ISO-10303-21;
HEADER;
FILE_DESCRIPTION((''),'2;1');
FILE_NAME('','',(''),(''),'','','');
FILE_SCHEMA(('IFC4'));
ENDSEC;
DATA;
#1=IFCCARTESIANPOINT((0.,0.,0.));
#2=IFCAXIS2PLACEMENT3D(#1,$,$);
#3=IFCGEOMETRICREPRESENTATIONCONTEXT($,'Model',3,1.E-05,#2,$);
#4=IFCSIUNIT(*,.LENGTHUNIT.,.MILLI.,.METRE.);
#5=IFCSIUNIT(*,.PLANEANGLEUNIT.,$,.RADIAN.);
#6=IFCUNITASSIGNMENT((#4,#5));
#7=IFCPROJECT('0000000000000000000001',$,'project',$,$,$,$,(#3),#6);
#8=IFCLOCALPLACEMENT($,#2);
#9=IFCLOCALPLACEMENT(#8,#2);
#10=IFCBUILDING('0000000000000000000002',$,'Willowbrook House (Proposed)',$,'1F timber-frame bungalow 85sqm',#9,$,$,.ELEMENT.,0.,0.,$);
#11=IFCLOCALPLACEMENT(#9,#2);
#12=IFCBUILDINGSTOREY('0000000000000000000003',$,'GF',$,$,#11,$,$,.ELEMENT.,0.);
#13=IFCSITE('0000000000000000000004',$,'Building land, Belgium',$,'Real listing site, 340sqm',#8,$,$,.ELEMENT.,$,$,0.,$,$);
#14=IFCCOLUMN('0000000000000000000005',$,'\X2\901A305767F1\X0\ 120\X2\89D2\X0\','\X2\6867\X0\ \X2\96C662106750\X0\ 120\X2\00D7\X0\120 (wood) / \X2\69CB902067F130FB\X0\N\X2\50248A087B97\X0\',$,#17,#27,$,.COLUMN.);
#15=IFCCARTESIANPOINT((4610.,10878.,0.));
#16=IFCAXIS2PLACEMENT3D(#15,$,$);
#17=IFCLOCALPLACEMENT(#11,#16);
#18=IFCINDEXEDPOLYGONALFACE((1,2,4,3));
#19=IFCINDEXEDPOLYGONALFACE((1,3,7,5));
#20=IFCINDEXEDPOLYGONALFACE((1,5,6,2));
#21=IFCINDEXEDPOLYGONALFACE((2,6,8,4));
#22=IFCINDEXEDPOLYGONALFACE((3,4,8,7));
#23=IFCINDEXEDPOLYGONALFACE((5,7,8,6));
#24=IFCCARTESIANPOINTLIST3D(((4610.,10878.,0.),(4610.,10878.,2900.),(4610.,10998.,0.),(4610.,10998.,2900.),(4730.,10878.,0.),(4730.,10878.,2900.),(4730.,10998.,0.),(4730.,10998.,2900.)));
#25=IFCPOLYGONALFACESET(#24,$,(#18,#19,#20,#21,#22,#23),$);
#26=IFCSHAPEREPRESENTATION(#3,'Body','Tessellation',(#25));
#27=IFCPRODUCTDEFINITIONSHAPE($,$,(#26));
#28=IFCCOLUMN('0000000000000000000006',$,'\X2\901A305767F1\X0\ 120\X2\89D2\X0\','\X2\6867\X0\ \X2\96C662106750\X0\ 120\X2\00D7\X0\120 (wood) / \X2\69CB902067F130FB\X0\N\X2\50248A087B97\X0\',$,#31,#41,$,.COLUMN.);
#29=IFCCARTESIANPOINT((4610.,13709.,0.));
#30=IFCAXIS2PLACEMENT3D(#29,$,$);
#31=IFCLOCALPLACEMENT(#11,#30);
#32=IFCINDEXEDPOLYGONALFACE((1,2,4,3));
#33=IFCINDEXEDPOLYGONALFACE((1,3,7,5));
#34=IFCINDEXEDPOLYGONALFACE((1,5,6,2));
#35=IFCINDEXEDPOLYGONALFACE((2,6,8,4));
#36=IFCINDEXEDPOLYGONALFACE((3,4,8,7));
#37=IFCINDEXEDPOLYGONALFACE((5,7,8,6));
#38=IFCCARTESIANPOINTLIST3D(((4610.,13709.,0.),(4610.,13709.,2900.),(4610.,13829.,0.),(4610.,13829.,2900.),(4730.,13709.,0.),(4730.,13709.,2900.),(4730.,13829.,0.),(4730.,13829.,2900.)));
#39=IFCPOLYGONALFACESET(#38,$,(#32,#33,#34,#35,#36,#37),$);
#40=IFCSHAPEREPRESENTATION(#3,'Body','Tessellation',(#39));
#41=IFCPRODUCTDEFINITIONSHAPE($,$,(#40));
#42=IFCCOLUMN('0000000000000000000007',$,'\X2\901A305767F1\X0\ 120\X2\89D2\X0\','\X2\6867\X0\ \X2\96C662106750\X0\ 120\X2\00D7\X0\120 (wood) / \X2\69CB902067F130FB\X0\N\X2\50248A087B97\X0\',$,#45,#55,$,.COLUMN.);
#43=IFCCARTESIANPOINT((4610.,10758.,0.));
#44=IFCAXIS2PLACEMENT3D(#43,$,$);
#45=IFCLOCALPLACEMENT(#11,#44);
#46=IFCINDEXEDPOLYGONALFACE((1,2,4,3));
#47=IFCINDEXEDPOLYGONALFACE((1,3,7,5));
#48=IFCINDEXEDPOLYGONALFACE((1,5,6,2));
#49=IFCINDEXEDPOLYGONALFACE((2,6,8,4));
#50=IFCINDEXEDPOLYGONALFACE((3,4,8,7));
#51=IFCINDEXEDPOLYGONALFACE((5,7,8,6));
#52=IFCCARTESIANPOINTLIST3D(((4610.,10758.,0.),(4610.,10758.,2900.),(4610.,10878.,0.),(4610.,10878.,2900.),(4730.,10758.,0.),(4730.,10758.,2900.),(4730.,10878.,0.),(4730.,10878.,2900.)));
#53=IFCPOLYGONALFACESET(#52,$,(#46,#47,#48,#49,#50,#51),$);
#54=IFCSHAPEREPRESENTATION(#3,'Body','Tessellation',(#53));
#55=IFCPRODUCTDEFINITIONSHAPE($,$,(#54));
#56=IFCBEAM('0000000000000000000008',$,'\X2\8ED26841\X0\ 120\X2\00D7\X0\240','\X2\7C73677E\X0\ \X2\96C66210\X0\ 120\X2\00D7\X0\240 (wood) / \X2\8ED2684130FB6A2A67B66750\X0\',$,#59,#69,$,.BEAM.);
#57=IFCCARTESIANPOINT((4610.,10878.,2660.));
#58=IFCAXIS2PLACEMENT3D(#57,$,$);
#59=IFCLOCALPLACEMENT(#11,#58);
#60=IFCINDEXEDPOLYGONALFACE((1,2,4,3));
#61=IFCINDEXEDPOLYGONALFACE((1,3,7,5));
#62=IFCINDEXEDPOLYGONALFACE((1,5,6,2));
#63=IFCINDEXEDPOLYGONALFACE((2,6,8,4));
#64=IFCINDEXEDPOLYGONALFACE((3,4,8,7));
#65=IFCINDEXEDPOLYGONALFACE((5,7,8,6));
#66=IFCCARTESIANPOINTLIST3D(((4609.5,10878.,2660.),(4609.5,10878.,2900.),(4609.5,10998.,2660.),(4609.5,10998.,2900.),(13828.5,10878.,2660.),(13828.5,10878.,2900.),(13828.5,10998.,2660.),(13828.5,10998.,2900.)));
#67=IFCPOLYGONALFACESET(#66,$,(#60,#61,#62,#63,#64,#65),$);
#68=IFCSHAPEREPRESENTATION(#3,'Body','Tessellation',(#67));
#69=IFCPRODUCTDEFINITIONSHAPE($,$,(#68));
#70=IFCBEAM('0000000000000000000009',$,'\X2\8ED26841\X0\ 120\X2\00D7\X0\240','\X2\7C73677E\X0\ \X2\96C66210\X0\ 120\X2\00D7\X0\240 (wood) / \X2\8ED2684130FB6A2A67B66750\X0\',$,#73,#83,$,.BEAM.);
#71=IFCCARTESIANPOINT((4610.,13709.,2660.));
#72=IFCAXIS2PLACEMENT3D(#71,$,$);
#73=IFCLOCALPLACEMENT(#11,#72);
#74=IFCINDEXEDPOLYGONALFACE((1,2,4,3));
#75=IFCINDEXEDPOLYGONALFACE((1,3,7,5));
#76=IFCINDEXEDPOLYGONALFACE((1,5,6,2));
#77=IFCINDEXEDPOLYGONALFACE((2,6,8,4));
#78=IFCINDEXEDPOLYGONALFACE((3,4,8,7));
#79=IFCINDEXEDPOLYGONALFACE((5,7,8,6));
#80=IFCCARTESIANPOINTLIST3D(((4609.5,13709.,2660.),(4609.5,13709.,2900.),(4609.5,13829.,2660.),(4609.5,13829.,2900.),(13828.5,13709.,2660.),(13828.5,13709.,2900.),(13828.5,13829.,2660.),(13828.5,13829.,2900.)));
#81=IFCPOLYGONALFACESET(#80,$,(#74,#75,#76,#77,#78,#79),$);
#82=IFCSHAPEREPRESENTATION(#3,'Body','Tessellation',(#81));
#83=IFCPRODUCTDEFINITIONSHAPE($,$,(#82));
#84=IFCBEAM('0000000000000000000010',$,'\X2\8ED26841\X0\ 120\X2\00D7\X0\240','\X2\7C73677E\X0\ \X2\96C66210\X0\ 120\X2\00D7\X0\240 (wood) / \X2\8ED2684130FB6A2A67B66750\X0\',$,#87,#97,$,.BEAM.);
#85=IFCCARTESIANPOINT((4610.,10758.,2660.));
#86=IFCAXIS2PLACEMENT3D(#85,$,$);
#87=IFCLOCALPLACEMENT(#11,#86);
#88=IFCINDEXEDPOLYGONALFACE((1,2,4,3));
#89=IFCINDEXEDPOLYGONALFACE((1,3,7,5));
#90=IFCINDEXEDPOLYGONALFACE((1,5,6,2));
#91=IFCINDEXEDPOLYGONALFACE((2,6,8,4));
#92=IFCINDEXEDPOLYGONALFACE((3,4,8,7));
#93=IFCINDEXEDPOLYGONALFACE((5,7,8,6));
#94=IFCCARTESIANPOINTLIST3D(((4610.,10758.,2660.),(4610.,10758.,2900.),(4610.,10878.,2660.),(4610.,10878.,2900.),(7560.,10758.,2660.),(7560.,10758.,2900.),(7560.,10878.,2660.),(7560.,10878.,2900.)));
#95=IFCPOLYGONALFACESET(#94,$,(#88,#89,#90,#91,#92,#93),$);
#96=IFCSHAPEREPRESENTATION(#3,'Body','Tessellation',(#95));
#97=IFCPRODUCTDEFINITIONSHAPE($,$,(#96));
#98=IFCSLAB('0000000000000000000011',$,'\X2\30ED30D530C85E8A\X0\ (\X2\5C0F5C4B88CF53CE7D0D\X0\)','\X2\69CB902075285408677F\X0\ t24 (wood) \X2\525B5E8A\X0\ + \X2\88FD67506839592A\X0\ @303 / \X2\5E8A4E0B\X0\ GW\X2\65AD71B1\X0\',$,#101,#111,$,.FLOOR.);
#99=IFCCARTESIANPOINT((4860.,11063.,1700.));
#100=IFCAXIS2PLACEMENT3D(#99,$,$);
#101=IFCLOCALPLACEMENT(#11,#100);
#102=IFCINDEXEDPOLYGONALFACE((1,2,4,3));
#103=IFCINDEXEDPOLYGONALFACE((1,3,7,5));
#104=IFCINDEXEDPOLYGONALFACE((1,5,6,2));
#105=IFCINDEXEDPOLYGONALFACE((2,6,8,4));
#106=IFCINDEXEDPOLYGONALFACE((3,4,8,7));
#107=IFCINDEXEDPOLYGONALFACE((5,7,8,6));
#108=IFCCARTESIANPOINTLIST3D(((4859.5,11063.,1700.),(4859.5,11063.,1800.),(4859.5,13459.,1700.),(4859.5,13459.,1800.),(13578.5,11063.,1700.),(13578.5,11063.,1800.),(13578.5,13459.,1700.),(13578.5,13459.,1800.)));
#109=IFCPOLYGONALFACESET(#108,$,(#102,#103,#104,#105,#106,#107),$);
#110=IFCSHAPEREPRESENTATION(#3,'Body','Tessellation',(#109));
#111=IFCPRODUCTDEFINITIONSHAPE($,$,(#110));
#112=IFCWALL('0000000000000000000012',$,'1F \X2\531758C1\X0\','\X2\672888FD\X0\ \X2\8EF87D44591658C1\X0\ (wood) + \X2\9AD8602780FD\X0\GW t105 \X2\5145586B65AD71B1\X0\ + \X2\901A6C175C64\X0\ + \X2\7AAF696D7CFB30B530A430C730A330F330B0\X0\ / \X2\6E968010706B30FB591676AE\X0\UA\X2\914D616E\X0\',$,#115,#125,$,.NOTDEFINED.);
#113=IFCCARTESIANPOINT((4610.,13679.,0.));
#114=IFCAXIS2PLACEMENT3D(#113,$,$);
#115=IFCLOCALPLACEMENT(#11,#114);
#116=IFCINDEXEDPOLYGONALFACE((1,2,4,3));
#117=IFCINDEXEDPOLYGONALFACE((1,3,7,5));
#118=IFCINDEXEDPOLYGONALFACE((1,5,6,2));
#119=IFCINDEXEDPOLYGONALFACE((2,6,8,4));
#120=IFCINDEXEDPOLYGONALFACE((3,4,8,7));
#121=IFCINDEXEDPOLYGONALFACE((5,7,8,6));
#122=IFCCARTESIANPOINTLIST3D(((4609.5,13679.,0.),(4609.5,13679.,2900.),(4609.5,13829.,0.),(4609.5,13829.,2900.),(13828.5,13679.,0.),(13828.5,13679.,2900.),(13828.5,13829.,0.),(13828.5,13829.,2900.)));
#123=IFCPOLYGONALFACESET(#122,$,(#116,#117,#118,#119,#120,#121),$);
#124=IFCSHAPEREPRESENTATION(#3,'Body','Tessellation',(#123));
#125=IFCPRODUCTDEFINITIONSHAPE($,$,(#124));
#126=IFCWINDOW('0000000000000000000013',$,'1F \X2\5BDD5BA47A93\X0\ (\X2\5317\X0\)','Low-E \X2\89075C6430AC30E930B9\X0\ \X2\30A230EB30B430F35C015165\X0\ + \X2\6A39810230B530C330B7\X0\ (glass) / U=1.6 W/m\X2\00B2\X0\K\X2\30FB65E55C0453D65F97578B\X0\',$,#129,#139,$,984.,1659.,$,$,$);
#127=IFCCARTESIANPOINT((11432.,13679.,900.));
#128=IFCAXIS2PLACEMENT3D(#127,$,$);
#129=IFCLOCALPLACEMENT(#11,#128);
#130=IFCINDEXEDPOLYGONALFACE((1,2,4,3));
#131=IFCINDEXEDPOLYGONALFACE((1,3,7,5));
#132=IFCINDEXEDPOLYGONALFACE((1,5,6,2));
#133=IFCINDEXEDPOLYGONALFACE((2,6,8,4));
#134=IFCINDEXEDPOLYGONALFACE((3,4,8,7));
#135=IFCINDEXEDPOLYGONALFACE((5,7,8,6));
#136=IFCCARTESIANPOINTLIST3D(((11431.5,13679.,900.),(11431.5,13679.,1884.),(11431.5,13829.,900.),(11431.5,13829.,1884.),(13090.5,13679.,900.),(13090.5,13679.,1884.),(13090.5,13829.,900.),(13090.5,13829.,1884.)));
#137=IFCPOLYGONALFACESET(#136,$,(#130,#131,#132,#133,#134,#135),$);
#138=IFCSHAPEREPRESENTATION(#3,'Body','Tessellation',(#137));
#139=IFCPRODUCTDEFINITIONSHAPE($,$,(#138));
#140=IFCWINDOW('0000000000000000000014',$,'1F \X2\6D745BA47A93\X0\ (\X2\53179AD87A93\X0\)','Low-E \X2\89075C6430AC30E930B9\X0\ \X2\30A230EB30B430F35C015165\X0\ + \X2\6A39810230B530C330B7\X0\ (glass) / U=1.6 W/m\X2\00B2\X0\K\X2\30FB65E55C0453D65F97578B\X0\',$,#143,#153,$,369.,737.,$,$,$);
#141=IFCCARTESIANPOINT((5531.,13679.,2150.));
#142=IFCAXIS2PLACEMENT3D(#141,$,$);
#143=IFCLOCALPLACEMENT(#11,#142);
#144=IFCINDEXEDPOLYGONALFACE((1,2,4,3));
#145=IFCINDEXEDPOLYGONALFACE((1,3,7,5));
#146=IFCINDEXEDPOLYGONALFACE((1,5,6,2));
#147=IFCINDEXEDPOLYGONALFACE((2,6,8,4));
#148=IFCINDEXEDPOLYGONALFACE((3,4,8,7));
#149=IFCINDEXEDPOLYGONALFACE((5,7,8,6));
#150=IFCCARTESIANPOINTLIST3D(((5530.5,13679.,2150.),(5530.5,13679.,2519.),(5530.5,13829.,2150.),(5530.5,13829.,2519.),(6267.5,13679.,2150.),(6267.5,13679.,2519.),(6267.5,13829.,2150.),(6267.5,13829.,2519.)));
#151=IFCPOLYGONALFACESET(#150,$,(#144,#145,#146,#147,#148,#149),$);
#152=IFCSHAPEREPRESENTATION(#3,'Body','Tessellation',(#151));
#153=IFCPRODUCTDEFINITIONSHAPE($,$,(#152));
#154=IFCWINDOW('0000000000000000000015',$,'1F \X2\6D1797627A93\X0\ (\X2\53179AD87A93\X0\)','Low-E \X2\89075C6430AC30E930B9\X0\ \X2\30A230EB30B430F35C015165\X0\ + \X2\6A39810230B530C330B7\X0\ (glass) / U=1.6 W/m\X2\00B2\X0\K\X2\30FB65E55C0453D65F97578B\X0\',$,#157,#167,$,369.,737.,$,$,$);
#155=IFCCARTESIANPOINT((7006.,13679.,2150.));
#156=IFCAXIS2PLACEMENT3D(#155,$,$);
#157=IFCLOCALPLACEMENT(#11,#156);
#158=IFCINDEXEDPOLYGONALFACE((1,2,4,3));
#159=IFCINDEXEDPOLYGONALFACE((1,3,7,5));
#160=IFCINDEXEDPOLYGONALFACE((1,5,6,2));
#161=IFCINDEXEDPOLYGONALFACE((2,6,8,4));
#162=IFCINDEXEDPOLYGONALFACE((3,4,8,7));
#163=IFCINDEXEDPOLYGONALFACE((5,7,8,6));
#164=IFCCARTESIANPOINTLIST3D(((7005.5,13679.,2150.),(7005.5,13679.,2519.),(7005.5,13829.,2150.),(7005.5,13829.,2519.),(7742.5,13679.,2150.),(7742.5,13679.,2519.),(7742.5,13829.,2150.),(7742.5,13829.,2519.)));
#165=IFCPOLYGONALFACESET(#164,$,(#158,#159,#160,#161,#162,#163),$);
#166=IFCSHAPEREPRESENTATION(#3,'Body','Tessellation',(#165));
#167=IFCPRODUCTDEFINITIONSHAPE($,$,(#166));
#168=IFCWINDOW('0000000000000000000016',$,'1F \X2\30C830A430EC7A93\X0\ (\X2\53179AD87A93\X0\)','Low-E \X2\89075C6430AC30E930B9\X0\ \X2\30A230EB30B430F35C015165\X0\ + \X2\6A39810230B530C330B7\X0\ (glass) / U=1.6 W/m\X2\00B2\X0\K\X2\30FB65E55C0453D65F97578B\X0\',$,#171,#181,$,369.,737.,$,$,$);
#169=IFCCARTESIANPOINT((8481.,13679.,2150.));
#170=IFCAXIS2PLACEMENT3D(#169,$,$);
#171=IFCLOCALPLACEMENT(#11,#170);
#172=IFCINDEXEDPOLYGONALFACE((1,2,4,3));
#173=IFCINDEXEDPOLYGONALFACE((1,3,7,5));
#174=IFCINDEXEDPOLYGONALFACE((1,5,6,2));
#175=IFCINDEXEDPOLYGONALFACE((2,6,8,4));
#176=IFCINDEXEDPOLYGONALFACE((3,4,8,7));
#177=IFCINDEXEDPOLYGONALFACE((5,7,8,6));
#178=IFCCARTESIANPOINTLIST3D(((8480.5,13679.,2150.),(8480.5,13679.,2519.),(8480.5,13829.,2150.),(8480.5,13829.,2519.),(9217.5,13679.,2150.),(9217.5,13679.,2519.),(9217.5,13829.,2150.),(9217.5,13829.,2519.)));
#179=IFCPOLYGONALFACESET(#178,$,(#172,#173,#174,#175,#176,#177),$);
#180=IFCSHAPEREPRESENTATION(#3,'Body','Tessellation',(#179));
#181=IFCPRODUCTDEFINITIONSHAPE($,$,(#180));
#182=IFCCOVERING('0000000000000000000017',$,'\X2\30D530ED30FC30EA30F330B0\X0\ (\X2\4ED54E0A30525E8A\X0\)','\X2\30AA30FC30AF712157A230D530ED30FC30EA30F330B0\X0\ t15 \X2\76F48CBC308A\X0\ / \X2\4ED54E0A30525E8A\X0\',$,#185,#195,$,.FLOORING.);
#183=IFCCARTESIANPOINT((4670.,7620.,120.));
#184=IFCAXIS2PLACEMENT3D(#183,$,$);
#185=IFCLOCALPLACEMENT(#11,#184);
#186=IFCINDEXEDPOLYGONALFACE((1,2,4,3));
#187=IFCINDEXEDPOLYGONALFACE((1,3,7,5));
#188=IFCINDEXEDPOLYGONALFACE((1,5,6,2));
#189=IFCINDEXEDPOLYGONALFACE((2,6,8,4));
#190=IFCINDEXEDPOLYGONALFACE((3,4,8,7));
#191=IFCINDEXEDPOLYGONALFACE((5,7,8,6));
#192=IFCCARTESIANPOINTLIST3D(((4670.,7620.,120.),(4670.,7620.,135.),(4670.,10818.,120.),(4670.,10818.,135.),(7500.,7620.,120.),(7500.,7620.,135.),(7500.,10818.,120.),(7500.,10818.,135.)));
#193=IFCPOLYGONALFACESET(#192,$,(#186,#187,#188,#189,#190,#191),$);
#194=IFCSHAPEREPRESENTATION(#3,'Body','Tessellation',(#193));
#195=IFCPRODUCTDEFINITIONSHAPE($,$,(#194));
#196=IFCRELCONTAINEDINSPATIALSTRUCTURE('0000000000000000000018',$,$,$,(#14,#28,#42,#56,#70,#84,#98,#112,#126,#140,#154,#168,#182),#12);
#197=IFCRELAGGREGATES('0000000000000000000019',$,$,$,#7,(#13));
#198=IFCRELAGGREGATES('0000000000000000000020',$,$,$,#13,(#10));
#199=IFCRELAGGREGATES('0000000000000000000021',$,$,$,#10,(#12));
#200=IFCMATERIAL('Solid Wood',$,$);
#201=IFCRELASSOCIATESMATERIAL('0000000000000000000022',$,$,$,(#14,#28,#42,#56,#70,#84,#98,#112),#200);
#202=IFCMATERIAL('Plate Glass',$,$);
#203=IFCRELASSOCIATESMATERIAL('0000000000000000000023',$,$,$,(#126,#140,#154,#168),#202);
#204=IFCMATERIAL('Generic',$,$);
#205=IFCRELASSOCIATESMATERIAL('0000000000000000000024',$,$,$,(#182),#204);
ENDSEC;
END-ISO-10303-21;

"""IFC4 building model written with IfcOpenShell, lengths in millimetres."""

from ifc_helpers import new_model, si_unit, frame, frame_2d, origin, place, context, project, spatial, rectangle, extrude, material, element, fill, save


model = new_model("IFC4")

# Units and contexts
model_context = context("Model", 3, precision=1e-05, world=origin())
ifc_project = project(units=[si_unit("LENGTHUNIT", "METRE", prefix="MILLI"), si_unit("PLANEANGLEUNIT", "RADIAN")], contexts=[model_context])

# Site, building, storey
site_placement = place(None, origin())
site = spatial("IfcSite", under=ifc_project, at=site_placement, Name="Building land, Belgium", ObjectType="Real listing site, 340sqm", CompositionType="ELEMENT", RefElevation=0.0)
building_placement = place(site_placement, origin())
building = spatial("IfcBuilding", under=site, at=building_placement, Name="Willowbrook House (Proposed)", ObjectType="1F timber-frame bungalow 85sqm", CompositionType="ELEMENT", ElevationOfRefHeight=0.0, ElevationOfTerrain=0.0)
storey_placement = place(building_placement, origin())
storey = spatial("IfcBuildingStorey", under=building, at=storey_placement, Name="GF", CompositionType="ELEMENT", Elevation=0.0)

# Columns
ifc_material_1 = material(Name="Solid Wood")
column_1_placement = place(storey_placement, frame((4610.0, 10878.0, 0.0)))
element("IfcColumn", 1, at=column_1_placement, inside=storey, material=ifc_material_1, Name="通し柱 120角", Description="桧 集成材 120×120 (wood) / 構造柱・N値計算", PredefinedType="COLUMN", context=model_context, shape_type="SweptSolid", body=[
    extrude(rectangle(XDim=120.0, YDim=120.0, at=frame_2d((60.0, 60.0))), frame((4610.0, 10878.0, 0.0)), (0.0, 0.0, 1.0), 2900.0),
])
column_2_placement = place(storey_placement, frame((4610.0, 13709.0, 0.0)))
element("IfcColumn", 2, at=column_2_placement, inside=storey, material=ifc_material_1, Name="通し柱 120角", Description="桧 集成材 120×120 (wood) / 構造柱・N値計算", PredefinedType="COLUMN", context=model_context, shape_type="SweptSolid", body=[
    extrude(rectangle(XDim=120.0, YDim=120.0, at=frame_2d((60.0, 60.0))), frame((4610.0, 13709.0, 0.0)), (0.0, 0.0, 1.0), 2900.0),
])
column_3_placement = place(storey_placement, frame((4610.0, 10758.0, 0.0)))
element("IfcColumn", 3, at=column_3_placement, inside=storey, material=ifc_material_1, Name="通し柱 120角", Description="桧 集成材 120×120 (wood) / 構造柱・N値計算", PredefinedType="COLUMN", context=model_context, shape_type="SweptSolid", body=[
    extrude(rectangle(XDim=120.0, YDim=120.0, at=frame_2d((60.0, 60.0))), frame((4610.0, 10758.0, 0.0)), (0.0, 0.0, 1.0), 2900.0),
])

# Beams
beam_1_placement = place(storey_placement, frame((4610.0, 10878.0, 2660.0)))
element("IfcBeam", 4, at=beam_1_placement, inside=storey, material=ifc_material_1, Name="軒桁 120×240", Description="米松 集成 120×240 (wood) / 軒桁・横架材", PredefinedType="BEAM", context=model_context, shape_type="SweptSolid", body=[
    extrude(rectangle(XDim=9219.0, YDim=120.0, at=frame_2d((4609.0, 60.0))), frame((4610.0, 10878.0, 2660.0)), (0.0, 0.0, 1.0), 240.0),
])
beam_2_placement = place(storey_placement, frame((4610.0, 13709.0, 2660.0)))
element("IfcBeam", 5, at=beam_2_placement, inside=storey, material=ifc_material_1, Name="軒桁 120×240", Description="米松 集成 120×240 (wood) / 軒桁・横架材", PredefinedType="BEAM", context=model_context, shape_type="SweptSolid", body=[
    extrude(rectangle(XDim=9219.0, YDim=120.0, at=frame_2d((4609.0, 60.0))), frame((4610.0, 13709.0, 2660.0)), (0.0, 0.0, 1.0), 240.0),
])
beam_3_placement = place(storey_placement, frame((4610.0, 10758.0, 2660.0)))
element("IfcBeam", 6, at=beam_3_placement, inside=storey, material=ifc_material_1, Name="軒桁 120×240", Description="米松 集成 120×240 (wood) / 軒桁・横架材", PredefinedType="BEAM", context=model_context, shape_type="SweptSolid", body=[
    extrude(rectangle(XDim=2950.0, YDim=120.0, at=frame_2d((1475.0, 60.0))), frame((4610.0, 10758.0, 2660.0)), (0.0, 0.0, 1.0), 240.0),
])

# Slab
slab_1_placement = place(storey_placement, frame((4860.0, 11063.0, 1700.0)))
element("IfcSlab", 7, at=slab_1_placement, inside=storey, material=ifc_material_1, Name="ロフト床 (小屋裏収納)", Description="構造用合板 t24 (wood) 剛床 + 製材根太 @303 / 床下 GW断熱", PredefinedType="FLOOR", context=model_context, shape_type="SweptSolid", body=[
    extrude(rectangle(XDim=8719.0, YDim=2396.0, at=frame_2d((4359.0, 1198.0))), frame((4860.0, 11063.0, 1700.0)), (0.0, 0.0, 1.0), 100.0),
])

# Wall, openings, windows
wall_1_placement = place(storey_placement, frame((4610.0, 13679.0, 0.0)))
wall_1 = element("IfcWall", 8, at=wall_1_placement, inside=storey, material=ifc_material_1, Name="1F 北壁", Description="木製 軸組外壁 (wood) + 高性能GW t105 充填断熱 + 通気層 + 窯業系サイディング / 準耐火・外皮UA配慮", PredefinedType="NOTDEFINED", context=model_context, shape_type="SweptSolid", body=[
    extrude(rectangle(XDim=9219.0, YDim=150.0, at=frame_2d((4609.0, 75.0))), frame((4610.0, 13679.0, 0.0)), (0.0, 0.0, 1.0), 2900.0),
])
opening_1_placement = place(storey_placement, frame((11432.0, 13679.0, 900.0)))
opening_1 = element("IfcOpeningElement", 9, at=opening_1_placement, cuts=wall_1, PredefinedType="NOTDEFINED", context=model_context, shape_type="SweptSolid", body=[
    extrude(rectangle(XDim=1659.0, YDim=150.0, at=frame_2d((829.0, 75.0))), frame((11432.0, 13679.0, 900.0)), (0.0, 0.0, 1.0), 984.0),
])
opening_2_placement = place(storey_placement, frame((5531.0, 13679.0, 2150.0)))
opening_2 = element("IfcOpeningElement", 10, at=opening_2_placement, cuts=wall_1, PredefinedType="NOTDEFINED", context=model_context, shape_type="SweptSolid", body=[
    extrude(rectangle(XDim=737.0, YDim=150.0, at=frame_2d((368.0, 75.0))), frame((5531.0, 13679.0, 2150.0)), (0.0, 0.0, 1.0), 369.0),
])
opening_3_placement = place(storey_placement, frame((7006.0, 13679.0, 2150.0)))
opening_3 = element("IfcOpeningElement", 11, at=opening_3_placement, cuts=wall_1, PredefinedType="NOTDEFINED", context=model_context, shape_type="SweptSolid", body=[
    extrude(rectangle(XDim=737.0, YDim=150.0, at=frame_2d((368.0, 75.0))), frame((7006.0, 13679.0, 2150.0)), (0.0, 0.0, 1.0), 369.0),
])
opening_4_placement = place(storey_placement, frame((8481.0, 13679.0, 2150.0)))
opening_4 = element("IfcOpeningElement", 12, at=opening_4_placement, cuts=wall_1, PredefinedType="NOTDEFINED", context=model_context, shape_type="SweptSolid", body=[
    extrude(rectangle(XDim=737.0, YDim=150.0, at=frame_2d((368.0, 75.0))), frame((8481.0, 13679.0, 2150.0)), (0.0, 0.0, 1.0), 369.0),
])
ifc_material_2 = material(Name="Plate Glass")
window_1_placement = place(storey_placement, frame((11432.0, 13679.0, 900.0)))
window_1 = element("IfcWindow", 13, at=window_1_placement, inside=storey, material=ifc_material_2, Name="1F 寝室窓 (北)", Description="Low-E 複層ガラス アルゴン封入 + 樹脂サッシ (glass) / U=1.6 W/m²K・日射取得型", OverallHeight=984.0, OverallWidth=1659.0, context=model_context, shape_type="SweptSolid", body=[
    extrude(rectangle(XDim=1659.0, YDim=150.0, at=frame_2d((829.0, 75.0))), frame((11432.0, 13679.0, 900.0)), (0.0, 0.0, 1.0), 984.0),
])
fill(opening_1, window_1)
window_2_placement = place(storey_placement, frame((5531.0, 13679.0, 2150.0)))
window_2 = element("IfcWindow", 14, at=window_2_placement, inside=storey, material=ifc_material_2, Name="1F 浴室窓 (北高窓)", Description="Low-E 複層ガラス アルゴン封入 + 樹脂サッシ (glass) / U=1.6 W/m²K・日射取得型", OverallHeight=369.0, OverallWidth=737.0, context=model_context, shape_type="SweptSolid", body=[
    extrude(rectangle(XDim=737.0, YDim=150.0, at=frame_2d((368.0, 75.0))), frame((5531.0, 13679.0, 2150.0)), (0.0, 0.0, 1.0), 369.0),
])
fill(opening_2, window_2)
window_3_placement = place(storey_placement, frame((7006.0, 13679.0, 2150.0)))
window_3 = element("IfcWindow", 15, at=window_3_placement, inside=storey, material=ifc_material_2, Name="1F 洗面窓 (北高窓)", Description="Low-E 複層ガラス アルゴン封入 + 樹脂サッシ (glass) / U=1.6 W/m²K・日射取得型", OverallHeight=369.0, OverallWidth=737.0, context=model_context, shape_type="SweptSolid", body=[
    extrude(rectangle(XDim=737.0, YDim=150.0, at=frame_2d((368.0, 75.0))), frame((7006.0, 13679.0, 2150.0)), (0.0, 0.0, 1.0), 369.0),
])
fill(opening_3, window_3)
window_4_placement = place(storey_placement, frame((8481.0, 13679.0, 2150.0)))
window_4 = element("IfcWindow", 16, at=window_4_placement, inside=storey, material=ifc_material_2, Name="1F トイレ窓 (北高窓)", Description="Low-E 複層ガラス アルゴン封入 + 樹脂サッシ (glass) / U=1.6 W/m²K・日射取得型", OverallHeight=369.0, OverallWidth=737.0, context=model_context, shape_type="SweptSolid", body=[
    extrude(rectangle(XDim=737.0, YDim=150.0, at=frame_2d((368.0, 75.0))), frame((8481.0, 13679.0, 2150.0)), (0.0, 0.0, 1.0), 369.0),
])
fill(opening_4, window_4)

# Covering
ifc_material_3 = material(Name="Generic")
covering_1_placement = place(storey_placement, frame((4670.0, 7620.0, 120.0)))
element("IfcCovering", 17, at=covering_1_placement, inside=storey, material=ifc_material_3, Name="フローリング (仕上げ床)", Description="オーク無垢フローリング t15 直貼り / 仕上げ床", PredefinedType="FLOORING", context=model_context, shape_type="SweptSolid", body=[
    extrude(rectangle(XDim=2830.0, YDim=3198.0, at=frame_2d((1415.0, 1599.0))), frame((4670.0, 7620.0, 120.0)), (0.0, 0.0, 1.0), 15.0),
])

save(model, "model.ifc")
